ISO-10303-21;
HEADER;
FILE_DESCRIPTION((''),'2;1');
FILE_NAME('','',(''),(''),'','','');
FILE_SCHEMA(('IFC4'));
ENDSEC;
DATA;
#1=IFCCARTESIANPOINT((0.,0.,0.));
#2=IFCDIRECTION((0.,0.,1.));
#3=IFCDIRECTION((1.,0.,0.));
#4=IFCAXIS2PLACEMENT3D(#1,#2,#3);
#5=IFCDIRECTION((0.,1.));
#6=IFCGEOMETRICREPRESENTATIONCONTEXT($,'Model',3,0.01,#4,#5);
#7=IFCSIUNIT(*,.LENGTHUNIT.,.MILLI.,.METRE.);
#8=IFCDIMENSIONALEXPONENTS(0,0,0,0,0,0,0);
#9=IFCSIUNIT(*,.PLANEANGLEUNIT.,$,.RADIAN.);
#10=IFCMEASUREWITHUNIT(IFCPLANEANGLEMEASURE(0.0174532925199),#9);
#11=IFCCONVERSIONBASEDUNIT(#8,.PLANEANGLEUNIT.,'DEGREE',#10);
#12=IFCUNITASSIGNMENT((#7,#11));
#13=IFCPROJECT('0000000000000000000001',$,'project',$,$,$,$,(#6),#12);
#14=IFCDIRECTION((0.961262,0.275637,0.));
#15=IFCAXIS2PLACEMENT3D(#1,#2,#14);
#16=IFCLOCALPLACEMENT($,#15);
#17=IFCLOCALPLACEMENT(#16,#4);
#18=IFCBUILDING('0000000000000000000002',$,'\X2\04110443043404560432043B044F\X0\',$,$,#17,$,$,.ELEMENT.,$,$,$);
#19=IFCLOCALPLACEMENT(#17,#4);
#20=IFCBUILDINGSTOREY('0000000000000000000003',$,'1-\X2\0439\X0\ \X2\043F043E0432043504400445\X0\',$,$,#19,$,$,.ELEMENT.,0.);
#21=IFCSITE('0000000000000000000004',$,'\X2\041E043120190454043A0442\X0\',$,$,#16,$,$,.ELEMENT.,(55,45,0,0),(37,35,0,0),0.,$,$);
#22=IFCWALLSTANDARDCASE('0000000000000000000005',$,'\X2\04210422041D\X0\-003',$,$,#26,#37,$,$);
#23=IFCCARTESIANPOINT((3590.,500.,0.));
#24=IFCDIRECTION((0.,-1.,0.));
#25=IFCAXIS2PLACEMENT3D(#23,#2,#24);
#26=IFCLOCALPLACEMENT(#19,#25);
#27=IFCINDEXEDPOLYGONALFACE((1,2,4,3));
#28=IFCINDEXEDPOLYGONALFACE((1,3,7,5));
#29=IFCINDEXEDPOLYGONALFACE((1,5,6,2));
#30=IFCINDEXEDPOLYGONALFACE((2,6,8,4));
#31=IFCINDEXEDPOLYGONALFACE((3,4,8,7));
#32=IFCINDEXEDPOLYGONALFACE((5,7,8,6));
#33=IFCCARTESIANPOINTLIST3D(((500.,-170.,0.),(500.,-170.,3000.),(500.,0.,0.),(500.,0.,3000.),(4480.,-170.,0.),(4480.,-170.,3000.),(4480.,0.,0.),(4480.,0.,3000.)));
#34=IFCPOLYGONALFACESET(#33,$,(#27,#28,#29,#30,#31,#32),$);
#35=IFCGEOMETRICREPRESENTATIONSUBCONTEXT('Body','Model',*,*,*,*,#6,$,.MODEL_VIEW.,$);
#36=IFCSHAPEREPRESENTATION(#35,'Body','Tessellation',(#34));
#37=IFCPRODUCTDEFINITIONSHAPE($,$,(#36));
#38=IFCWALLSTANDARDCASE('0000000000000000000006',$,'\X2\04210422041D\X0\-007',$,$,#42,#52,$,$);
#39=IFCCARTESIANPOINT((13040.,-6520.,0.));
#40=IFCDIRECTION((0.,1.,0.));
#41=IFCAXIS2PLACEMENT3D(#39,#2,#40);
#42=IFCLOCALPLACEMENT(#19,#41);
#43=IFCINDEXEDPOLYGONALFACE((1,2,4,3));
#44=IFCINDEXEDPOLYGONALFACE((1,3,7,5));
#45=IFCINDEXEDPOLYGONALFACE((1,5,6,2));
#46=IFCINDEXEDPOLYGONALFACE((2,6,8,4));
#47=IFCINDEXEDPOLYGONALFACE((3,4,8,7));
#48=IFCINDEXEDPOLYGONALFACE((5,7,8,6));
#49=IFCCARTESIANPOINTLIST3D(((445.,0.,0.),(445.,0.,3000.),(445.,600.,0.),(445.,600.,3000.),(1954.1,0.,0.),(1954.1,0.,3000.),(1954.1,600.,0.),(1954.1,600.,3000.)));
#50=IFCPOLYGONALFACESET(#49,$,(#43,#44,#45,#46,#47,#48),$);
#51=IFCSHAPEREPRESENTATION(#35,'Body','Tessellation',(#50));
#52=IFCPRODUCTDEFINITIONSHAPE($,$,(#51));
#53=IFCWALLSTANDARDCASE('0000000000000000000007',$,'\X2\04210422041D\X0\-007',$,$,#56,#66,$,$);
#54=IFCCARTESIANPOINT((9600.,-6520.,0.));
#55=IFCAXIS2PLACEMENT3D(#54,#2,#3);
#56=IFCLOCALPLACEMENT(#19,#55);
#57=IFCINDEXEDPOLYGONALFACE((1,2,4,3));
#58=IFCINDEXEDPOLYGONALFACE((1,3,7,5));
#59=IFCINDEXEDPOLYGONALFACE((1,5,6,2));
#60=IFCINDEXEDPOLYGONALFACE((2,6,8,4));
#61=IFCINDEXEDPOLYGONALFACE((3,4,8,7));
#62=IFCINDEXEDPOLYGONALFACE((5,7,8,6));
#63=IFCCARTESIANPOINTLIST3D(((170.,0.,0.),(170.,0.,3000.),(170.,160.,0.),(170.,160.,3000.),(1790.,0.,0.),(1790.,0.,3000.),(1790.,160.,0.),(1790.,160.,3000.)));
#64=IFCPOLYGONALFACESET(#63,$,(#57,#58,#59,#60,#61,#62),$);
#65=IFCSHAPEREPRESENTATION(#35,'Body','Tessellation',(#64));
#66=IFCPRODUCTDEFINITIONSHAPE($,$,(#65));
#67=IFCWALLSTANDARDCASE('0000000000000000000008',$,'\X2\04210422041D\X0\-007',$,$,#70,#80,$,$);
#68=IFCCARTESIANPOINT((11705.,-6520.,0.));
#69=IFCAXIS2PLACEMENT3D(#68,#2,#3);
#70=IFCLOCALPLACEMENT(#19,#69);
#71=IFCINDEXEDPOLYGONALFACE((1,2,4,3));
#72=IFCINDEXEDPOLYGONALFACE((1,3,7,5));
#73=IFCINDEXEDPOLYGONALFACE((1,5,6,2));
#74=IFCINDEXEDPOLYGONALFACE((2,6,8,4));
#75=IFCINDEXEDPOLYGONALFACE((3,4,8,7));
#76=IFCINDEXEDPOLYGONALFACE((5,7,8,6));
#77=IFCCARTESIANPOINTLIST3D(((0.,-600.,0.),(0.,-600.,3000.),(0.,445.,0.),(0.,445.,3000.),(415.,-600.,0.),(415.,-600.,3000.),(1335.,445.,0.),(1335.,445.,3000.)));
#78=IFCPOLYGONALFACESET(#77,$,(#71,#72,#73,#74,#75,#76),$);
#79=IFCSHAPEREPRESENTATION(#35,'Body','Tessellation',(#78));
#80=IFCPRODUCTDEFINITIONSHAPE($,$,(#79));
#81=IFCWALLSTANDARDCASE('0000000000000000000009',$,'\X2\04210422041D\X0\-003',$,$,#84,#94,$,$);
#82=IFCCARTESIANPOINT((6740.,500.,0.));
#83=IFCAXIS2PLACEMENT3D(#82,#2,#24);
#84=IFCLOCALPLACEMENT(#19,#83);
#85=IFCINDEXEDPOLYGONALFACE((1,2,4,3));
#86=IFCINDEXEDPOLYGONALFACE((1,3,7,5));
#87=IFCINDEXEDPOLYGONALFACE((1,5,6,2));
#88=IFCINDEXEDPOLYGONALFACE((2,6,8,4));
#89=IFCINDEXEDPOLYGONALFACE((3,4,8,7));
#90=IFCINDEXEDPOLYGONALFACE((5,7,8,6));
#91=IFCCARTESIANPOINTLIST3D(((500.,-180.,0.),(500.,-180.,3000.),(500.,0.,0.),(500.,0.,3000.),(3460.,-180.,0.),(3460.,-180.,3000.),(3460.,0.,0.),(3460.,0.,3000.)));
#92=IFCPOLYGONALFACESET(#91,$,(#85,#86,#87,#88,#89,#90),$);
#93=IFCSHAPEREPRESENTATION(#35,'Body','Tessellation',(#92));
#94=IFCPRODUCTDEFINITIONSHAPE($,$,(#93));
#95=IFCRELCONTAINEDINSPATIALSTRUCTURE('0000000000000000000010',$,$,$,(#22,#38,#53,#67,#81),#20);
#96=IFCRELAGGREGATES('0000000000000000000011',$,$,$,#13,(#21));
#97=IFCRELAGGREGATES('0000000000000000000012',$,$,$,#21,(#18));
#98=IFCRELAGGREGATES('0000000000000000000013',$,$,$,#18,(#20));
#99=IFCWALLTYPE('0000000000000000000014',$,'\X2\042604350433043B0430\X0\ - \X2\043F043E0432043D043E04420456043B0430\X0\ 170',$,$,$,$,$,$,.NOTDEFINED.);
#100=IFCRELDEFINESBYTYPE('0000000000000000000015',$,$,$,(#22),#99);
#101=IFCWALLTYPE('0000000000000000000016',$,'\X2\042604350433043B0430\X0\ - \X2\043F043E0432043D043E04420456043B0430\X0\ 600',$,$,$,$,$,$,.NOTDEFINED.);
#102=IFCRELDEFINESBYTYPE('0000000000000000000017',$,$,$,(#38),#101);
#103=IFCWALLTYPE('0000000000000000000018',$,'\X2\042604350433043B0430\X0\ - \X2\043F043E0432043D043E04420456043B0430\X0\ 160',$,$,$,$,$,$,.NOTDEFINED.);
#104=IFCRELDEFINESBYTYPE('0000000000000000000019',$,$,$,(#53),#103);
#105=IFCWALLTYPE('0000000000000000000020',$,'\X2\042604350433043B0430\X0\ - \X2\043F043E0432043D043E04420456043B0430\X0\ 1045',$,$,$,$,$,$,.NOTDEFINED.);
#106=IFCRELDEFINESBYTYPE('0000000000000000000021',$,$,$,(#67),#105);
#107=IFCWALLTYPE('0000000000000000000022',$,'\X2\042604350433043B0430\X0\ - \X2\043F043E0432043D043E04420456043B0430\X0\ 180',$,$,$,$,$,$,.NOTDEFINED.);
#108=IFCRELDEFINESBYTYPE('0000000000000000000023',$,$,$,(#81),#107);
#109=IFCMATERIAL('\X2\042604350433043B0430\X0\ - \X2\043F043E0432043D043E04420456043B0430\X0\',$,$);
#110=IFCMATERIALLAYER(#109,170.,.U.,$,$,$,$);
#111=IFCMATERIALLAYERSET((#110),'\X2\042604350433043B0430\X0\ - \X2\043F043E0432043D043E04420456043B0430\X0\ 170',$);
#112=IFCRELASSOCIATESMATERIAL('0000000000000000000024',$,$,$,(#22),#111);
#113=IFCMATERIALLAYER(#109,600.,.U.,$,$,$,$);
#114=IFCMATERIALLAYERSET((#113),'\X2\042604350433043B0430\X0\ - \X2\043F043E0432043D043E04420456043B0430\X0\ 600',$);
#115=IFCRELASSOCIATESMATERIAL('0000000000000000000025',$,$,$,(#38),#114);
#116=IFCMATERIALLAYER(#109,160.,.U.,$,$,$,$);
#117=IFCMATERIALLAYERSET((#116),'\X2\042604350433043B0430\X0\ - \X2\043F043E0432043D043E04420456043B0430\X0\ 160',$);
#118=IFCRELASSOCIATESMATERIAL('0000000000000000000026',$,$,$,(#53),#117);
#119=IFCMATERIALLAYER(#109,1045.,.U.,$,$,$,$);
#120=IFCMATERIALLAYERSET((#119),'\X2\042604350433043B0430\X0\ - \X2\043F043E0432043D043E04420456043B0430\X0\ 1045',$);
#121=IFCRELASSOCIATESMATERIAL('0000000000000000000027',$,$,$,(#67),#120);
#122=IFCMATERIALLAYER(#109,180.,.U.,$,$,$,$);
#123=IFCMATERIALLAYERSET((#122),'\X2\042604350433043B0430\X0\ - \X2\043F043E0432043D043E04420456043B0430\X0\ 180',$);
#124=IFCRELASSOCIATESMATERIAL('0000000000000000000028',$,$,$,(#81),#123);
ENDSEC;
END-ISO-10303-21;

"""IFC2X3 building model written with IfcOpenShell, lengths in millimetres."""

from ifc_helpers import new_model, entity, si_unit, converted_unit, direction, frame, origin_with_axes, place, context, subcontext, project, spatial, polyline, outline, extrude, material, layer, layer_set, layer_usage, type_object, element, save


model = new_model("IFC2X3")

# Units and contexts
model_context = context("Model", 3, precision=0.01, world=origin_with_axes(), true_north=direction((0.0, 1.0)))
body_context = subcontext(model_context, "Body", "Model", "MODEL_VIEW")
ifc_project = project(units=[si_unit("LENGTHUNIT", "METRE", prefix="MILLI"), converted_unit("PLANEANGLEUNIT", "DEGREE", entity("IfcPlaneAngleMeasure", 0.0174532925199), si_unit("PLANEANGLEUNIT", "RADIAN"), dimensions=[0, 0, 0, 0, 0, 0, 0])], contexts=[model_context])

# Site, building, storey
site_placement = place(None, frame((0.0, 0.0, 0.0), z_axis=(0.0, 0.0, 1.0), x_axis=(0.961262, 0.275637, 0.0)))
site = spatial("IfcSite", under=ifc_project, at=site_placement, Name="Об’єкт", CompositionType="ELEMENT", RefLatitude=(55, 45, 0, 0), RefLongitude=(37, 35, 0, 0), RefElevation=0.0)
building_placement = place(site_placement, origin_with_axes())
building = spatial("IfcBuilding", under=site, at=building_placement, Name="Будівля", CompositionType="ELEMENT")
storey_placement = place(building_placement, origin_with_axes())
storey = spatial("IfcBuildingStorey", under=building, at=storey_placement, Name="1-й поверх", CompositionType="ELEMENT", Elevation=0.0)

# Walls
ifc_material_1 = material(Name="Цегла - повнотіла")
ifc_layer_1 = layer(ifc_material_1, 170.0, ventilated="UNKNOWN")
ifc_layer_set_1 = layer_set([ifc_layer_1], Name="Цегла - повнотіла 170")
wall_type_1 = type_object("IfcWallType", Name="Цегла - повнотіла 170", PredefinedType="NOTDEFINED")
ifc_layer_usage_1 = layer_usage(ifc_layer_set_1, "AXIS2", "POSITIVE", -170.0)
wall_1_placement = place(storey_placement, frame((3590.0, 500.0, 0.0), z_axis=(0.0, 0.0, 1.0), x_axis=(0.0, -1.0, 0.0)))
element("IfcWallStandardCase", 1, at=wall_1_placement, inside=storey, type_object=wall_type_1, material=ifc_layer_usage_1, Name="СТН-003", context=body_context, shape_type="SweptSolid", body=[
    extrude(outline(polyline([(500.0, -170.0), (4480.0, -170.0), (4480.0, 0.0), (500.0, 0.0), (500.0, -170.0)])), origin_with_axes(), (0.0, 0.0, 1.0), 3000.0),
])
ifc_layer_2 = layer(ifc_material_1, 600.0, ventilated="UNKNOWN")
ifc_layer_set_2 = layer_set([ifc_layer_2], Name="Цегла - повнотіла 600")
ifc_layer_usage_2 = layer_usage(ifc_layer_set_2, "AXIS2", "POSITIVE", 0.0)
wall_type_2 = type_object("IfcWallType", Name="Цегла - повнотіла 600", PredefinedType="NOTDEFINED")
wall_2_placement = place(storey_placement, frame((13040.0, -6520.0, 0.0), z_axis=(0.0, 0.0, 1.0), x_axis=(0.0, 1.0, 0.0)))
element("IfcWallStandardCase", 2, at=wall_2_placement, inside=storey, type_object=wall_type_2, material=ifc_layer_usage_2, Name="СТН-007", context=body_context, shape_type="SweptSolid", body=[
    extrude(outline(polyline([(445.0, 0.0), (1954.1, 0.0), (1954.1, 600.0), (445.0, 600.0), (445.0, 0.0)])), origin_with_axes(), (0.0, 0.0, 1.0), 3000.0),
])
ifc_layer_3 = layer(ifc_material_1, 160.0, ventilated="UNKNOWN")
ifc_layer_set_3 = layer_set([ifc_layer_3], Name="Цегла - повнотіла 160")
ifc_layer_usage_3 = layer_usage(ifc_layer_set_3, "AXIS2", "POSITIVE", 0.0)
wall_type_3 = type_object("IfcWallType", Name="Цегла - повнотіла 160", PredefinedType="NOTDEFINED")
wall_3_placement = place(storey_placement, frame((9600.0, -6520.0, 0.0), z_axis=(0.0, 0.0, 1.0), x_axis=(1.0, 0.0, 0.0)))
element("IfcWallStandardCase", 3, at=wall_3_placement, inside=storey, type_object=wall_type_3, material=ifc_layer_usage_3, Name="СТН-007", context=body_context, shape_type="SweptSolid", body=[
    extrude(outline(polyline([(170.0, 0.0), (1790.0, 0.0), (1790.0, 160.0), (170.0, 160.0), (170.0, 0.0)])), origin_with_axes(), (0.0, 0.0, 1.0), 3000.0),
])
ifc_layer_4 = layer(ifc_material_1, 1045.0, ventilated="UNKNOWN")
ifc_layer_set_4 = layer_set([ifc_layer_4], Name="Цегла - повнотіла 1045")
ifc_layer_usage_4 = layer_usage(ifc_layer_set_4, "AXIS2", "POSITIVE", -600.0)
wall_type_4 = type_object("IfcWallType", Name="Цегла - повнотіла 1045", PredefinedType="NOTDEFINED")
wall_4_placement = place(storey_placement, frame((11705.0, -6520.0, 0.0), z_axis=(0.0, 0.0, 1.0), x_axis=(1.0, 0.0, 0.0)))
element("IfcWallStandardCase", 4, at=wall_4_placement, inside=storey, type_object=wall_type_4, material=ifc_layer_usage_4, Name="СТН-007", context=body_context, shape_type="SweptSolid", body=[
    extrude(outline(polyline([(0.0, -600.0), (415.0, -600.0), (1335.0, 445.0), (0.0, 445.0), (0.0, -600.0)])), origin_with_axes(), (0.0, 0.0, 1.0), 3000.0),
])
ifc_layer_5 = layer(ifc_material_1, 180.0, ventilated="UNKNOWN")
ifc_layer_set_5 = layer_set([ifc_layer_5], Name="Цегла - повнотіла 180")
ifc_layer_usage_5 = layer_usage(ifc_layer_set_5, "AXIS2", "POSITIVE", -180.0)
wall_type_5 = type_object("IfcWallType", Name="Цегла - повнотіла 180", PredefinedType="NOTDEFINED")
wall_5_placement = place(storey_placement, frame((6740.0, 500.0, 0.0), z_axis=(0.0, 0.0, 1.0), x_axis=(0.0, -1.0, 0.0)))
element("IfcWallStandardCase", 5, at=wall_5_placement, inside=storey, type_object=wall_type_5, material=ifc_layer_usage_5, Name="СТН-003", context=body_context, shape_type="SweptSolid", body=[
    extrude(outline(polyline([(500.0, -180.0), (3460.0, -180.0), (3460.0, 0.0), (500.0, 0.0), (500.0, -180.0)])), origin_with_axes(), (0.0, 0.0, 1.0), 3000.0),
])

save(model, "model.ifc")
